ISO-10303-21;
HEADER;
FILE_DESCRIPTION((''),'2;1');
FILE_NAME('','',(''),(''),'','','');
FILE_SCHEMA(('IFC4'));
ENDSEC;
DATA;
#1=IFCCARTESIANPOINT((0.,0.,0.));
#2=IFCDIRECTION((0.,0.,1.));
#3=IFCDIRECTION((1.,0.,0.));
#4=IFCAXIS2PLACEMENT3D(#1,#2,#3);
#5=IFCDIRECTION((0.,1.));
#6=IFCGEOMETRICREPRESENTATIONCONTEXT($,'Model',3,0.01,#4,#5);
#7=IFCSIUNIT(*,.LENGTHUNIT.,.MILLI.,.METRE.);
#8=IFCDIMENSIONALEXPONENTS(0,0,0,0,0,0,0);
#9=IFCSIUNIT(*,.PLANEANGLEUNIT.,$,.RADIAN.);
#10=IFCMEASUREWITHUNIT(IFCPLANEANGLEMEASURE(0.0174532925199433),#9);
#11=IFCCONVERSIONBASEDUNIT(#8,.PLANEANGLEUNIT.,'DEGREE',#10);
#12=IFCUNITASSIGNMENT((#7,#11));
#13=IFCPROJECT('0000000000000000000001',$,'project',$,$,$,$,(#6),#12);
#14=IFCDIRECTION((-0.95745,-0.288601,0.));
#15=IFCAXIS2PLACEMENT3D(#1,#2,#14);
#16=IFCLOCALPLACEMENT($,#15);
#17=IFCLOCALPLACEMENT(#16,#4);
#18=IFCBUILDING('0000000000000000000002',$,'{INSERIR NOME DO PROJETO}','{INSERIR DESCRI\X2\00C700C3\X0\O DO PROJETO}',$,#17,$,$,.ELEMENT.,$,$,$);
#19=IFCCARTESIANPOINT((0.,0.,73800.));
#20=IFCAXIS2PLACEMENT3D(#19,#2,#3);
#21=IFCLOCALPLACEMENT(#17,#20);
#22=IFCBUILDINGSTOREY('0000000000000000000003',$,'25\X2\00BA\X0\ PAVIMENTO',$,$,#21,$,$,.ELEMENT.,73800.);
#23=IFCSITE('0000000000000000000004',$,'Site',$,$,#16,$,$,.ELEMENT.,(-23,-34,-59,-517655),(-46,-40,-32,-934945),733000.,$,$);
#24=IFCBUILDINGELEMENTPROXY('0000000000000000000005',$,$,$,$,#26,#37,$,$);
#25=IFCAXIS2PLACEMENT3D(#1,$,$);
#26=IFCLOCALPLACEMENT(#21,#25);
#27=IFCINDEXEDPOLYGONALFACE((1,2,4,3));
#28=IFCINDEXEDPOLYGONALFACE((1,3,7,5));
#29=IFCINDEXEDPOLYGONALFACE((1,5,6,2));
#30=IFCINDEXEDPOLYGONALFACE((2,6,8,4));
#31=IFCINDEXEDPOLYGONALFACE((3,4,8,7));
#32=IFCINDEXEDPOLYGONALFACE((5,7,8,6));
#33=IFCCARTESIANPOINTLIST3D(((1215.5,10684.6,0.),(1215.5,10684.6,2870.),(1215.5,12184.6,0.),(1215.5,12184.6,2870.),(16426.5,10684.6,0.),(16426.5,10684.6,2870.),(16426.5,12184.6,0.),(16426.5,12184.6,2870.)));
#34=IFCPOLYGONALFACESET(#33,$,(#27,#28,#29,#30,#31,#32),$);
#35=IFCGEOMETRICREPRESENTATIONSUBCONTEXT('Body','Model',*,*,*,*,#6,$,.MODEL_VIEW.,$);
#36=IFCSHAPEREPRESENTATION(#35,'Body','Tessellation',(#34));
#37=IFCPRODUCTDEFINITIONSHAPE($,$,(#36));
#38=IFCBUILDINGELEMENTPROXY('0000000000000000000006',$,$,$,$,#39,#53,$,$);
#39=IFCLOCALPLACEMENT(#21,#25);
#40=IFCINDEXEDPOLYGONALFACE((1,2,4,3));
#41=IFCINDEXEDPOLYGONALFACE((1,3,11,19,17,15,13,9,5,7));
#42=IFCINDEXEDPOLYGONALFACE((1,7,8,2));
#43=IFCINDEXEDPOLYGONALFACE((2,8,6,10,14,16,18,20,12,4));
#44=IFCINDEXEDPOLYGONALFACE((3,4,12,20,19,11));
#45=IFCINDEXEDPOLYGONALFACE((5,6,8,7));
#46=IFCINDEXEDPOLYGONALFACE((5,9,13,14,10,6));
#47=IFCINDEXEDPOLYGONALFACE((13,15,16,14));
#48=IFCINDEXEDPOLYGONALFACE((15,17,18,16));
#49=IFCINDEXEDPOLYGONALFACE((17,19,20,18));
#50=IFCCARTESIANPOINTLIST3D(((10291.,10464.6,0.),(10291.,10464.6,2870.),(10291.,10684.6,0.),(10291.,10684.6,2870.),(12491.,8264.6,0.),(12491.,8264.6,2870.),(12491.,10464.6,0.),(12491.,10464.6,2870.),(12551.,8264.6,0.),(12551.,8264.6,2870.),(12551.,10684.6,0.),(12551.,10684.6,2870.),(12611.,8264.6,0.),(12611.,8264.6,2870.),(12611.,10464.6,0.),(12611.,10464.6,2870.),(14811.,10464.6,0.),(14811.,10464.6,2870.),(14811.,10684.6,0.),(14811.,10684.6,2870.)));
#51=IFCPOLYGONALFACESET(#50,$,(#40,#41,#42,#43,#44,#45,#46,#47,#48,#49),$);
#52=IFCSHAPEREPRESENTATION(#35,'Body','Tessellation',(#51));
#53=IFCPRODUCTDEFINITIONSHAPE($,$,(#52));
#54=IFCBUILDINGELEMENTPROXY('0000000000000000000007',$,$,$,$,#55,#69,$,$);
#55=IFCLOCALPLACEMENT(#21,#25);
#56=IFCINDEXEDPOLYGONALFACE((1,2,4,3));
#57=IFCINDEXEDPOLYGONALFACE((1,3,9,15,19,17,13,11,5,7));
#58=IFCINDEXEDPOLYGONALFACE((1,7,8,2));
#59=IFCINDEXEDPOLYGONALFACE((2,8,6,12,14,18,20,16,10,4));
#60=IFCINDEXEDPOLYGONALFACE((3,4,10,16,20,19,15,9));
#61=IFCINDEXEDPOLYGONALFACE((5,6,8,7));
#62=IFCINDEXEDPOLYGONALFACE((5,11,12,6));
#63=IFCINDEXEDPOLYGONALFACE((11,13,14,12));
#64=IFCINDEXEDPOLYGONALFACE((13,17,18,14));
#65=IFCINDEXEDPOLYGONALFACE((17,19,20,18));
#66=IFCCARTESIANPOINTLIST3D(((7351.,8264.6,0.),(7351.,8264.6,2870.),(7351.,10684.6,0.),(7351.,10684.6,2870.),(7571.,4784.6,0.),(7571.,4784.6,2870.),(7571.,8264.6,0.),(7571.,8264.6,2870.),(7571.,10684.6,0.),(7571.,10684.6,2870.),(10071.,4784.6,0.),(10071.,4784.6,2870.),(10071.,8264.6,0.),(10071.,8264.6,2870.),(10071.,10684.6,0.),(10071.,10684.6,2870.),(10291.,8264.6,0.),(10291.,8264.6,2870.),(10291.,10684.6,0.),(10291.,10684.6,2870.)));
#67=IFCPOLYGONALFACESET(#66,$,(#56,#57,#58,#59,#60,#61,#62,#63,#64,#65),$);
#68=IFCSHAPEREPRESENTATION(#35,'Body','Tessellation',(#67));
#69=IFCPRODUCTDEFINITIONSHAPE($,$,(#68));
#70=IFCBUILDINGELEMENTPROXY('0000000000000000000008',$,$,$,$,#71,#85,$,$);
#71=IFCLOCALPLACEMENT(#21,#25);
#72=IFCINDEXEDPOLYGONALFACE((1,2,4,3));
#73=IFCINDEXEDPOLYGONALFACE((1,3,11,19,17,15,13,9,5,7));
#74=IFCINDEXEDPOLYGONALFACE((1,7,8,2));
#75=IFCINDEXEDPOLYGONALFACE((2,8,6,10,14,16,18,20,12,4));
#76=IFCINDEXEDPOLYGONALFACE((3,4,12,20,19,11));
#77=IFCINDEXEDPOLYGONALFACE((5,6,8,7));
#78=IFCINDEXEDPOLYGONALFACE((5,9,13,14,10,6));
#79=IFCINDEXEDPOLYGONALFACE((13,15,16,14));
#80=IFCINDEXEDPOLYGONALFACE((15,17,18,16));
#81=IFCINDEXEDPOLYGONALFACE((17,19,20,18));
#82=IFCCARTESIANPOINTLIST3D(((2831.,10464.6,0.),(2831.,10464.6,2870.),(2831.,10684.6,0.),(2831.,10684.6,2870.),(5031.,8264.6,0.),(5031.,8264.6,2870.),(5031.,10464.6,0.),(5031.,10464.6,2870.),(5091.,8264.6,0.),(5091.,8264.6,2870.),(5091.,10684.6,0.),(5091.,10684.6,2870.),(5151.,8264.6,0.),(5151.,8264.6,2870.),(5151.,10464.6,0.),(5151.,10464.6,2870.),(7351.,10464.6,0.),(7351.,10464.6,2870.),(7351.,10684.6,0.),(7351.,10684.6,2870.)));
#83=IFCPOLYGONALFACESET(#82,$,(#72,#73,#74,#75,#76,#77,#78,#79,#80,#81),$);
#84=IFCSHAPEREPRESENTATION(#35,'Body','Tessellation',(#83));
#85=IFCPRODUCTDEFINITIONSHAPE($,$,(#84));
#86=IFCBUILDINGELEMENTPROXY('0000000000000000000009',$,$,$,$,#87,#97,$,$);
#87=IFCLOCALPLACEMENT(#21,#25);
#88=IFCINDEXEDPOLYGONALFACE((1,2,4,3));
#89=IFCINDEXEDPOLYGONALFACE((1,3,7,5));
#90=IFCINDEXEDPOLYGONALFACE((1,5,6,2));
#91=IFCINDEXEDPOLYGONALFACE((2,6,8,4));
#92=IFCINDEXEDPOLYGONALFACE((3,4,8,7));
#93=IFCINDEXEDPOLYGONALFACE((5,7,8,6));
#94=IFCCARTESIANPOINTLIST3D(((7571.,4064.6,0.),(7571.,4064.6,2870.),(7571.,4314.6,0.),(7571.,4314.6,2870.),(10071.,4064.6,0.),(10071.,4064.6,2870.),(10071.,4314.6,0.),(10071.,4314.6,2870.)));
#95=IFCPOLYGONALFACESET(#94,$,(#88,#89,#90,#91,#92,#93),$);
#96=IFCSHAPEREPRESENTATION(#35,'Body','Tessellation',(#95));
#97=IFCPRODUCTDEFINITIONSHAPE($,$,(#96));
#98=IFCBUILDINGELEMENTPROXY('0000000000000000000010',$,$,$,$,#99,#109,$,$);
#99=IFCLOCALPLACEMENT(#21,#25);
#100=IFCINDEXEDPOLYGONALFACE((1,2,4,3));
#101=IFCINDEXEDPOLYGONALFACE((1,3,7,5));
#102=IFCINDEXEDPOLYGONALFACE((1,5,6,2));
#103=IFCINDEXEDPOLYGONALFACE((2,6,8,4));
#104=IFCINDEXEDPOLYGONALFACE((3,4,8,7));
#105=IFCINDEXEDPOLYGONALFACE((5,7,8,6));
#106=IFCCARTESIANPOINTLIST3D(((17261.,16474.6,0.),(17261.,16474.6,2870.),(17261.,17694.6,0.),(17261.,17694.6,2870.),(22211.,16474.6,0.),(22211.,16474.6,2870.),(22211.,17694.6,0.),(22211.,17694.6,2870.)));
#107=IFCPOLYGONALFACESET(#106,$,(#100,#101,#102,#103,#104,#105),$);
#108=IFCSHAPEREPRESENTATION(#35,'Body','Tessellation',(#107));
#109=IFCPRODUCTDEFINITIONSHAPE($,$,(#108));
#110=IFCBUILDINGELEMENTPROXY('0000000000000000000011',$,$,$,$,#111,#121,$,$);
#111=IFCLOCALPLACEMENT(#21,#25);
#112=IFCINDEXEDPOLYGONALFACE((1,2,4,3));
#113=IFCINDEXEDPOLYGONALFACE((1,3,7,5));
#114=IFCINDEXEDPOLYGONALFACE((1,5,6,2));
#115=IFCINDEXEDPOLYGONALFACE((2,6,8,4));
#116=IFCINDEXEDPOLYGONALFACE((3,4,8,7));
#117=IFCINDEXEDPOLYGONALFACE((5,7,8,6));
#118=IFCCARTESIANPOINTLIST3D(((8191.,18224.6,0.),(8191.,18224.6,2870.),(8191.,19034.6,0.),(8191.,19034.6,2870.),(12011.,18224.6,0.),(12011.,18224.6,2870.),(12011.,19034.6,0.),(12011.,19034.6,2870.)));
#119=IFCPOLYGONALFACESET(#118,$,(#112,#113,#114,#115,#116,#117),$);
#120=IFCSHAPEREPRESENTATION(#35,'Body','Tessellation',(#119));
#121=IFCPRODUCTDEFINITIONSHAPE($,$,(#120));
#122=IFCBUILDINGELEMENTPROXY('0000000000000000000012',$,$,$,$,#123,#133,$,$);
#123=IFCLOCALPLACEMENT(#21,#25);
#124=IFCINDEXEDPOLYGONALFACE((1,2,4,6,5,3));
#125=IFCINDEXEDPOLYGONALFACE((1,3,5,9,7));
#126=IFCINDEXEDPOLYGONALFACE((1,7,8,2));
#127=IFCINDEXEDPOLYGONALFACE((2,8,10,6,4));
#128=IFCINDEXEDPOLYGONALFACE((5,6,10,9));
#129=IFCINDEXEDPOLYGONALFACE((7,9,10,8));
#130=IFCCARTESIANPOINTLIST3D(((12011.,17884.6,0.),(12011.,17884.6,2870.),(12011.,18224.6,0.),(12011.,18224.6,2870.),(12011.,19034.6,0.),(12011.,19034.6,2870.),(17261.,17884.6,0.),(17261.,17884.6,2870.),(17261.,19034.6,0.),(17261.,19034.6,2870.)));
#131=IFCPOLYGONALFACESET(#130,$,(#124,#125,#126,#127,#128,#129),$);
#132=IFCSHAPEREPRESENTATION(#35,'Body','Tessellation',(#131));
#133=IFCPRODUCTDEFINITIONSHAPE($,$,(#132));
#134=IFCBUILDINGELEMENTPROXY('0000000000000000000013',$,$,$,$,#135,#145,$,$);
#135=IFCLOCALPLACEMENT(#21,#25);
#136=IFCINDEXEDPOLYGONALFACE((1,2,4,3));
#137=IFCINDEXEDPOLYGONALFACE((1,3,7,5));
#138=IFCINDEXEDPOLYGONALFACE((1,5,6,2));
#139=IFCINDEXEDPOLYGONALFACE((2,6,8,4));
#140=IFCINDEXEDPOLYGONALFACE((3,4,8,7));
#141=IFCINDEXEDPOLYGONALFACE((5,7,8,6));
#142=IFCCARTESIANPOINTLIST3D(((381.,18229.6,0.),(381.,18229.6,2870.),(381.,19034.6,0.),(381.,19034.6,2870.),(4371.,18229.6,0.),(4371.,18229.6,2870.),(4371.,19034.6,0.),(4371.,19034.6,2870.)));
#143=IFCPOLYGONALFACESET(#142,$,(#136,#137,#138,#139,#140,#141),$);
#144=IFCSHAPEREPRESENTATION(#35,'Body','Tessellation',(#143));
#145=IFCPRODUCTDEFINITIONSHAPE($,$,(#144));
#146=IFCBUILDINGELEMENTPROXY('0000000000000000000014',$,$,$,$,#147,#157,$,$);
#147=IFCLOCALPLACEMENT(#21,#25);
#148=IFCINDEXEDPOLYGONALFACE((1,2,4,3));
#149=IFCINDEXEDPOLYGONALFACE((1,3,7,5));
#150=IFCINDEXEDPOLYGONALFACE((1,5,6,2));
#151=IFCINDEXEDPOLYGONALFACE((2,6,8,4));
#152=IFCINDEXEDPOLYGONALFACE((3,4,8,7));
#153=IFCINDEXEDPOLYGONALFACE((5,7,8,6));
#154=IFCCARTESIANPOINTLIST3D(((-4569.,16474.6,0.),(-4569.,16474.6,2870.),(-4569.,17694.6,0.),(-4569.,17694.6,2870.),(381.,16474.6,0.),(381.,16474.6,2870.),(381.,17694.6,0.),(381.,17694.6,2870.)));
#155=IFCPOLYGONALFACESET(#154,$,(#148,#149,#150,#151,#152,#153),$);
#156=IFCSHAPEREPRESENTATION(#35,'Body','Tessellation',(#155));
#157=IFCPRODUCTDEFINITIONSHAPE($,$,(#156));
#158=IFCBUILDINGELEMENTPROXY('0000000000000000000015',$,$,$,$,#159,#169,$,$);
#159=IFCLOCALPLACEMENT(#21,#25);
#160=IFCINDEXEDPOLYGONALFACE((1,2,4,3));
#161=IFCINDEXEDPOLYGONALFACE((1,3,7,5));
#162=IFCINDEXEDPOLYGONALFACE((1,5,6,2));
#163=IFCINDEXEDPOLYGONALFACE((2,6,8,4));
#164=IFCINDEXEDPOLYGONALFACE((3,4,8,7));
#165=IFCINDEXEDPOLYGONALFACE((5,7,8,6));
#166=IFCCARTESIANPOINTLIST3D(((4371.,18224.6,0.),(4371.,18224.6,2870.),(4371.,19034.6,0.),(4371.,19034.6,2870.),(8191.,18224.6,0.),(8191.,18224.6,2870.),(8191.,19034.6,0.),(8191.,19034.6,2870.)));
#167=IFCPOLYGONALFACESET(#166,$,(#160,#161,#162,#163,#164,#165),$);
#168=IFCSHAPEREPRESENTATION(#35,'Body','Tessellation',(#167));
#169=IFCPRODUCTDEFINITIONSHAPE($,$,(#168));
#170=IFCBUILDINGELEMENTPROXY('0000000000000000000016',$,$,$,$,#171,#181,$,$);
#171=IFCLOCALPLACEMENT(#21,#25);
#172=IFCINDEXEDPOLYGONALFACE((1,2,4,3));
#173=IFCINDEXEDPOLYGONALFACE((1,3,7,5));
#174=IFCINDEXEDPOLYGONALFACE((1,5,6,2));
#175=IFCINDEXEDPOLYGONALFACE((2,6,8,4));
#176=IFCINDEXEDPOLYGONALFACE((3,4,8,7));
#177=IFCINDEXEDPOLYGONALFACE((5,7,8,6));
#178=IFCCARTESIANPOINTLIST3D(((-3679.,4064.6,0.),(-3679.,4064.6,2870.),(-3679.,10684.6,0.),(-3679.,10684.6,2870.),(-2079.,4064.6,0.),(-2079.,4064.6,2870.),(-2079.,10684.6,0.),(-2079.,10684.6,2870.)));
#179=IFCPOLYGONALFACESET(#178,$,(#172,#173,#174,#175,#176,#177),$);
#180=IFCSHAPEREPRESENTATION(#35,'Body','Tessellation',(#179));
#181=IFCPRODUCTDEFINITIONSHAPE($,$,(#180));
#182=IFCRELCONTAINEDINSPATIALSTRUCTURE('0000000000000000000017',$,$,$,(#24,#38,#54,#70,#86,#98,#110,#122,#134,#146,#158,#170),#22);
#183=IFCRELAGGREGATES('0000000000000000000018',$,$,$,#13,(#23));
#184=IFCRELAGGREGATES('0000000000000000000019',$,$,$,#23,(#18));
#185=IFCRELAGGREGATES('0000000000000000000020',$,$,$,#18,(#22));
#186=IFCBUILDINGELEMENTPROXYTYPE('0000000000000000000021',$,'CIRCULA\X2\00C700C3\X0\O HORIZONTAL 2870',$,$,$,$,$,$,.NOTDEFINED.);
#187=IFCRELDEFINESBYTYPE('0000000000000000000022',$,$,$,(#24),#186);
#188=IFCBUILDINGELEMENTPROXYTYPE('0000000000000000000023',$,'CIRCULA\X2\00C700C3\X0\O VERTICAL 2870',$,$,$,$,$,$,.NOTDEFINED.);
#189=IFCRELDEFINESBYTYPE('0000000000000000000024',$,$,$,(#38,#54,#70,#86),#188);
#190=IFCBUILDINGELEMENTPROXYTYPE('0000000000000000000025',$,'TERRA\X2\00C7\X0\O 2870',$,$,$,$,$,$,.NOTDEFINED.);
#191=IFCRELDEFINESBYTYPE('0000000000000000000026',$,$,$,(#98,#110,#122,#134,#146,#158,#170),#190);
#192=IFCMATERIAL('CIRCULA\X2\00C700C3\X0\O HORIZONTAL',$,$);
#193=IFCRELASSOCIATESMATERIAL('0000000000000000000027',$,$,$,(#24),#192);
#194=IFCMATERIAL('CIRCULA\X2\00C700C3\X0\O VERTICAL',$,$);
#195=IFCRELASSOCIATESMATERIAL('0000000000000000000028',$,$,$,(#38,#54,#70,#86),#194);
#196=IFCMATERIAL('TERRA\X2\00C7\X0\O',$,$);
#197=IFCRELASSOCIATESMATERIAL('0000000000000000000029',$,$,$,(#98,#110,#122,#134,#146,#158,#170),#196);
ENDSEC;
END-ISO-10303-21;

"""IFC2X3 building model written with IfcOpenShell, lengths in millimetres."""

from ifc_helpers import new_model, entity, si_unit, converted_unit, direction, frame, origin_with_axes, place, context, subcontext, project, spatial, polyline, outline, extrude, material, type_object, element, save


model = new_model("IFC2X3")

# Units and contexts
model_context = context("Model", 3, precision=0.01, world=origin_with_axes(), true_north=direction((0.0, 1.0)))
body_context = subcontext(model_context, "Body", "Model", "MODEL_VIEW")
ifc_project = project(units=[si_unit("LENGTHUNIT", "METRE", prefix="MILLI"), converted_unit("PLANEANGLEUNIT", "DEGREE", entity("IfcPlaneAngleMeasure", 0.0174532925199433), si_unit("PLANEANGLEUNIT", "RADIAN"), dimensions=[0, 0, 0, 0, 0, 0, 0])], contexts=[model_context])

# Site, building, storey
site_placement = place(None, frame((0.0, 0.0, 0.0), z_axis=(0.0, 0.0, 1.0), x_axis=(-0.95745, -0.288601, 0.0)))
site = spatial("IfcSite", under=ifc_project, at=site_placement, Name="Site", CompositionType="ELEMENT", RefLatitude=(-23, -34, -59, -517655), RefLongitude=(-46, -40, -32, -934945), RefElevation=733000.0)
building_placement = place(site_placement, origin_with_axes())
building = spatial("IfcBuilding", under=site, at=building_placement, Name="{INSERIR NOME DO PROJETO}", Description="{INSERIR DESCRIÇÃO DO PROJETO}", CompositionType="ELEMENT")
storey_placement = place(building_placement, frame((0.0, 0.0, 73800.0), z_axis=(0.0, 0.0, 1.0), x_axis=(1.0, 0.0, 0.0)))
storey = spatial("IfcBuildingStorey", under=building, at=storey_placement, Name="25º PAVIMENTO", CompositionType="ELEMENT", Elevation=73800.0)

# Building element proxies
ifc_material_1 = material(Name="CIRCULAÇÃO HORIZONTAL")
building_element_proxy_type_1 = type_object("IfcBuildingElementProxyType", Name="CIRCULAÇÃO HORIZONTAL 2870", PredefinedType="NOTDEFINED")
proxy_1_placement = place(storey_placement, frame((1215.5, 10684.6, 0.0), z_axis=(0.0, 0.0, 1.0), x_axis=(1.0, 0.0, 0.0)))
element("IfcBuildingElementProxy", 1, at=proxy_1_placement, inside=storey, type_object=building_element_proxy_type_1, material=ifc_material_1, context=body_context, shape_type="SweptSolid", body=[
    extrude(outline(polyline([(0.0, 0.0), (15211.0, 0.0), (15211.0, 1500.0), (0.0, 1500.0), (0.0, 0.0)])), origin_with_axes(), (0.0, 0.0, 1.0), 2870.0),
])
ifc_material_2 = material(Name="CIRCULAÇÃO VERTICAL")
building_element_proxy_type_2 = type_object("IfcBuildingElementProxyType", Name="CIRCULAÇÃO VERTICAL 2870", PredefinedType="NOTDEFINED")
proxy_2_placement = place(storey_placement, frame((10291.0, 10684.6, 0.0), z_axis=(0.0, 0.0, 1.0), x_axis=(1.0, 0.0, 0.0)))
element("IfcBuildingElementProxy", 2, at=proxy_2_placement, inside=storey, type_object=building_element_proxy_type_2, material=ifc_material_2, context=body_context, shape_type="SweptSolid", body=[
    extrude(outline(polyline([(0.0, 0.0), (0.0, -220.0), (2200.0, -220.0), (2200.0, -2420.0), (2260.0, -2420.0), (2320.0, -2420.0), (2320.0, -220.0), (4520.0, -220.0), (4520.0, 0.0), (2260.0, 0.0), (0.0, 0.0)])), origin_with_axes(), (0.0, 0.0, 1.0), 2870.0),
])
proxy_3_placement = place(storey_placement, frame((7351.0, 10684.6, 0.0), z_axis=(0.0, 0.0, 1.0), x_axis=(1.0, 0.0, 0.0)))
element("IfcBuildingElementProxy", 3, at=proxy_3_placement, inside=storey, type_object=building_element_proxy_type_2, material=ifc_material_2, context=body_context, shape_type="SweptSolid", body=[
    extrude(outline(polyline([(0.0, 0.0), (0.0, -2420.0), (220.0, -2420.0), (220.0, -5900.0), (2720.0, -5900.0), (2720.0, -2420.0), (2940.0, -2420.0), (2940.0, 0.0), (2720.0, 0.0), (220.0, 0.0), (0.0, 0.0)])), origin_with_axes(), (0.0, 0.0, 1.0), 2870.0),
])
proxy_4_placement = place(storey_placement, frame((5091.0, 10684.6, 0.0), z_axis=(0.0, 0.0, 1.0), x_axis=(1.0, 0.0, 0.0)))
element("IfcBuildingElementProxy", 4, at=proxy_4_placement, inside=storey, type_object=building_element_proxy_type_2, material=ifc_material_2, context=body_context, shape_type="SweptSolid", body=[
    extrude(outline(polyline([(0.0, 0.0), (-2260.0, 0.0), (-2260.0, -220.0), (-60.0, -220.0), (-60.0, -2420.0), (0.0, -2420.0), (60.0, -2420.0), (60.0, -220.0), (2260.0, -220.0), (2260.0, 0.0), (0.0, 0.0)])), origin_with_axes(), (0.0, 0.0, 1.0), 2870.0),
])
proxy_5_placement = place(storey_placement, frame((7571.0, 4064.6, 0.0), z_axis=(0.0, 0.0, 1.0), x_axis=(1.0, 0.0, 0.0)))
element("IfcBuildingElementProxy", 5, at=proxy_5_placement, inside=storey, type_object=building_element_proxy_type_2, material=ifc_material_2, context=body_context, shape_type="SweptSolid", body=[
    extrude(outline(polyline([(0.0, 0.0), (2500.0, 0.0), (2500.0, 250.0), (0.0, 250.0), (0.0, 0.0)])), origin_with_axes(), (0.0, 0.0, 1.0), 2870.0),
])
ifc_material_3 = material(Name="TERRAÇO")
building_element_proxy_type_3 = type_object("IfcBuildingElementProxyType", Name="TERRAÇO 2870", PredefinedType="NOTDEFINED")
proxy_6_placement = place(storey_placement, frame((17261.0, 16474.6, 0.0), z_axis=(0.0, 0.0, 1.0), x_axis=(1.0, 0.0, 0.0)))
element("IfcBuildingElementProxy", 6, at=proxy_6_placement, inside=storey, type_object=building_element_proxy_type_3, material=ifc_material_3, context=body_context, shape_type="SweptSolid", body=[
    extrude(outline(polyline([(0.0, 0.0), (4950.0, 0.0), (4950.0, 1220.0), (0.0, 1220.0), (0.0, 0.0)])), origin_with_axes(), (0.0, 0.0, 1.0), 2870.0),
])
proxy_7_placement = place(storey_placement, frame((8191.0, 18224.6, 0.0), z_axis=(0.0, 0.0, 1.0), x_axis=(1.0, 0.0, 0.0)))
element("IfcBuildingElementProxy", 7, at=proxy_7_placement, inside=storey, type_object=building_element_proxy_type_3, material=ifc_material_3, context=body_context, shape_type="SweptSolid", body=[
    extrude(outline(polyline([(0.0, 0.0), (3820.0, 0.0), (3820.0, 810.0), (0.0, 810.0), (0.0, 0.0)])), origin_with_axes(), (0.0, 0.0, 1.0), 2870.0),
])
proxy_8_placement = place(storey_placement, frame((12011.0, 19034.6, 0.0), z_axis=(0.0, 0.0, 1.0), x_axis=(1.0, 0.0, 0.0)))
element("IfcBuildingElementProxy", 8, at=proxy_8_placement, inside=storey, type_object=building_element_proxy_type_3, material=ifc_material_3, context=body_context, shape_type="SweptSolid", body=[
    extrude(outline(polyline([(0.0, 0.0), (0.0, -810.0), (0.0, -1150.0), (5250.0, -1150.0), (5250.0, 0.0), (0.0, 0.0)])), origin_with_axes(), (0.0, 0.0, 1.0), 2870.0),
])
proxy_9_placement = place(storey_placement, frame((381.0, 19034.6, 0.0), z_axis=(0.0, 0.0, 1.0), x_axis=(1.0, 0.0, 0.0)))
element("IfcBuildingElementProxy", 9, at=proxy_9_placement, inside=storey, type_object=building_element_proxy_type_3, material=ifc_material_3, context=body_context, shape_type="SweptSolid", body=[
    extrude(outline(polyline([(0.0, 0.0), (0.0, -805.0), (3990.0, -805.0), (3990.0, 0.0), (0.0, 0.0)])), origin_with_axes(), (0.0, 0.0, 1.0), 2870.0),
])
proxy_10_placement = place(storey_placement, frame((381.0, 17694.6, 0.0), z_axis=(0.0, 0.0, 1.0), x_axis=(1.0, 0.0, 0.0)))
element("IfcBuildingElementProxy", 10, at=proxy_10_placement, inside=storey, type_object=building_element_proxy_type_3, material=ifc_material_3, context=body_context, shape_type="SweptSolid", body=[
    extrude(outline(polyline([(0.0, 0.0), (-4950.0, 0.0), (-4950.0, -1220.0), (0.0, -1220.0), (0.0, 0.0)])), origin_with_axes(), (0.0, 0.0, 1.0), 2870.0),
])
proxy_11_placement = place(storey_placement, frame((4371.0, 18224.6, 0.0), z_axis=(0.0, 0.0, 1.0), x_axis=(1.0, 0.0, 0.0)))
element("IfcBuildingElementProxy", 11, at=proxy_11_placement, inside=storey, type_object=building_element_proxy_type_3, material=ifc_material_3, context=body_context, shape_type="SweptSolid", body=[
    extrude(outline(polyline([(0.0, 0.0), (3820.0, 0.0), (3820.0, 810.0), (0.0, 810.0), (0.0, 0.0)])), origin_with_axes(), (0.0, 0.0, 1.0), 2870.0),
])
proxy_12_placement = place(storey_placement, frame((-3679.0, 4064.6, 0.0), z_axis=(0.0, 0.0, 1.0), x_axis=(1.0, 0.0, 0.0)))
element("IfcBuildingElementProxy", 12, at=proxy_12_placement, inside=storey, type_object=building_element_proxy_type_3, material=ifc_material_3, context=body_context, shape_type="SweptSolid", body=[
    extrude(outline(polyline([(0.0, 0.0), (1600.0, 0.0), (1600.0, 6620.0), (0.0, 6620.0), (0.0, 0.0)])), origin_with_axes(), (0.0, 0.0, 1.0), 2870.0),
])

save(model, "model.ifc")
